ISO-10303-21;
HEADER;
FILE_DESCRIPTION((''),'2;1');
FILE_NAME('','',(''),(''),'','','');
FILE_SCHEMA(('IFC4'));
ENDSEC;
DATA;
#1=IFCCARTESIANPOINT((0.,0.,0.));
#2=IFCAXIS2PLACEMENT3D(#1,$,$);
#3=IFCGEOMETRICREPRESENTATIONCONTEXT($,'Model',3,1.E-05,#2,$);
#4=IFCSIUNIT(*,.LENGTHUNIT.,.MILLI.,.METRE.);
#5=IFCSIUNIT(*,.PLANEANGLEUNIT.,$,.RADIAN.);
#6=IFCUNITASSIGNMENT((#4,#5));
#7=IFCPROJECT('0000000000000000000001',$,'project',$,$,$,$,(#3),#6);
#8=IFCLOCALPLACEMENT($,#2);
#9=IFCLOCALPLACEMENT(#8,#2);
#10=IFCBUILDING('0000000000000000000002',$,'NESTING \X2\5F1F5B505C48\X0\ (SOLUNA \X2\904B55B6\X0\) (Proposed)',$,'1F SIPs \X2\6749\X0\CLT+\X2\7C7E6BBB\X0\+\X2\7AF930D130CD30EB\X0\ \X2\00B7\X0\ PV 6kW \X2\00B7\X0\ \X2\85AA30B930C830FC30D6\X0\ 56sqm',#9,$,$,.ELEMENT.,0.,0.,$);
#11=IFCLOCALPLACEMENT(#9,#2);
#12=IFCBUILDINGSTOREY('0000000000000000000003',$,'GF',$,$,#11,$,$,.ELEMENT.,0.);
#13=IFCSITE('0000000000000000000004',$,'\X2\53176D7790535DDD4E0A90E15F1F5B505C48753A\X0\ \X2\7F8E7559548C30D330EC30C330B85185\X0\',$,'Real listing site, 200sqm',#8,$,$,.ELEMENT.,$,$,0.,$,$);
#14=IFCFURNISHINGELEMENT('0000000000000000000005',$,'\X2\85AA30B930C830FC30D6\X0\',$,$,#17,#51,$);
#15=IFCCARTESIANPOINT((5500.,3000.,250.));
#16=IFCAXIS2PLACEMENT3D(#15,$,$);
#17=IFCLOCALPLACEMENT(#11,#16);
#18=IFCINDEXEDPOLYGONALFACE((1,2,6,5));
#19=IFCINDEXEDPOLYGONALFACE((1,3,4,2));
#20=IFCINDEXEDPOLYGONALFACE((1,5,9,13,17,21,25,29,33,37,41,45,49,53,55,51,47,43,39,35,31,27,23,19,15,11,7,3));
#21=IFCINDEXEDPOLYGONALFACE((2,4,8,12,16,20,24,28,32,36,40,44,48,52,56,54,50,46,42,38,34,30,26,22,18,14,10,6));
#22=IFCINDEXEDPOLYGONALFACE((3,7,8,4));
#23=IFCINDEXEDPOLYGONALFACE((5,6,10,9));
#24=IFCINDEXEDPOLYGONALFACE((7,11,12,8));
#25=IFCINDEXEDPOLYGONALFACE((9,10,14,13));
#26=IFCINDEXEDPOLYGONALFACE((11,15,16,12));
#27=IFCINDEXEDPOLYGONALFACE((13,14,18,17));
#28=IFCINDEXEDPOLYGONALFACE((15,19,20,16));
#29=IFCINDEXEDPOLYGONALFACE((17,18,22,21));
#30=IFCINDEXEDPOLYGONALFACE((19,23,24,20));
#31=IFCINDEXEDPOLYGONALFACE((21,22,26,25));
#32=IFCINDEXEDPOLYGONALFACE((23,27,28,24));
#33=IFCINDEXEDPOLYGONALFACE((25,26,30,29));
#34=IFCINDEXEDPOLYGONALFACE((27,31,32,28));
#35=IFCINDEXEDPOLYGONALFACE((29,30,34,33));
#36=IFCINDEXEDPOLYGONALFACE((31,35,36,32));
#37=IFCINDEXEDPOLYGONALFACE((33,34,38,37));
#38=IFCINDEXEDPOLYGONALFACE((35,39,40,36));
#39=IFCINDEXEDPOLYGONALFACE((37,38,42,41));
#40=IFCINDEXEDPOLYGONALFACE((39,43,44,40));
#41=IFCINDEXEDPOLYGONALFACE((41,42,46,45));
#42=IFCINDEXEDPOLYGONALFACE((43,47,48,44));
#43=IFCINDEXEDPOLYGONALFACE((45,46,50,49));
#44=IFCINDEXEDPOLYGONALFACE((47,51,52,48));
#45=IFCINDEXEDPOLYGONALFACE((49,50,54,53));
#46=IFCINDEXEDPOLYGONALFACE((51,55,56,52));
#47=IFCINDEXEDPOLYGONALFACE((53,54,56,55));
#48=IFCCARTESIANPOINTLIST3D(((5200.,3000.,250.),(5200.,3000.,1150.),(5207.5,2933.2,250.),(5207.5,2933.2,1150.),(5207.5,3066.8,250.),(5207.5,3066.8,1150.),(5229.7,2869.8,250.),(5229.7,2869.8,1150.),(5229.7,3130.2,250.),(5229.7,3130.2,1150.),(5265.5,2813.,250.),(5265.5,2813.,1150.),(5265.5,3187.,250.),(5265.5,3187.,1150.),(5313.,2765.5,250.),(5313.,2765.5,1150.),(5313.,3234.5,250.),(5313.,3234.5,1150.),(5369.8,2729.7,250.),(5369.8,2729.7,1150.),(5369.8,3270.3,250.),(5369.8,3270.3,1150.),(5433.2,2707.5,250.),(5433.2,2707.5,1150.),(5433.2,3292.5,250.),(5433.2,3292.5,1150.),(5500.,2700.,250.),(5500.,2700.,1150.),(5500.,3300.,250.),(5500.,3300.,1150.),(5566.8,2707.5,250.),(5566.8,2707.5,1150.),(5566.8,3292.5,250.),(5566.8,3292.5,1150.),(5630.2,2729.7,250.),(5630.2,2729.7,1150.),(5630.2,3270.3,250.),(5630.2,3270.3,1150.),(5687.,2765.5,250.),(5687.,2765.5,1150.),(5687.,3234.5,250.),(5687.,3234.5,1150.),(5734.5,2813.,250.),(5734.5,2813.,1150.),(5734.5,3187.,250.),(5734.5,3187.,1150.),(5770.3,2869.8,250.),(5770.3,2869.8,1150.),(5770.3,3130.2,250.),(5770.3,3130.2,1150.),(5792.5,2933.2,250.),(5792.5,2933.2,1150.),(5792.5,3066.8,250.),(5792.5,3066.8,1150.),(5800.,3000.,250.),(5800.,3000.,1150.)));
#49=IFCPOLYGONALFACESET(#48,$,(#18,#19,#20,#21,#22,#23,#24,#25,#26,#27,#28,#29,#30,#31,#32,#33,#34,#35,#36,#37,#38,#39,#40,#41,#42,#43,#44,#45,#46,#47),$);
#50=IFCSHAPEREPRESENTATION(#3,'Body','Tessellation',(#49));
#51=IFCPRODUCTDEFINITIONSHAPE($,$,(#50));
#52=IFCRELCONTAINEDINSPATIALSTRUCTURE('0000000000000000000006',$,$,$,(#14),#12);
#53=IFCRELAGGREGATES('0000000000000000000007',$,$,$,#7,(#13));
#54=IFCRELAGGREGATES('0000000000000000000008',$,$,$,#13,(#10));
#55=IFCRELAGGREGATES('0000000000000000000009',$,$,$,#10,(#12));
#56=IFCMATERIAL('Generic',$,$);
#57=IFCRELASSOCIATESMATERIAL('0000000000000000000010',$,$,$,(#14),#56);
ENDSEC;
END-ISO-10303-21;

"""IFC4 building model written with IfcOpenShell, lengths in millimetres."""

from ifc_helpers import new_model, si_unit, frame, origin, origin_2d, place, context, project, spatial, circle, extrude, material, element, save


model = new_model("IFC4")

# Units and contexts
model_context = context("Model", 3, precision=1e-05, world=origin())
ifc_project = project(units=[si_unit("LENGTHUNIT", "METRE", prefix="MILLI"), si_unit("PLANEANGLEUNIT", "RADIAN")], contexts=[model_context])

# Site, building, storey
site_placement = place(None, origin())
site = spatial("IfcSite", under=ifc_project, at=site_placement, Name="北海道川上郡弟子屈町 美留和ビレッジ内", ObjectType="Real listing site, 200sqm", CompositionType="ELEMENT", RefElevation=0.0)
building_placement = place(site_placement, origin())
building = spatial("IfcBuilding", under=site, at=building_placement, Name="NESTING 弟子屈 (SOLUNA 運営) (Proposed)", ObjectType="1F SIPs 杉CLT+籾殻+竹パネル · PV 6kW · 薪ストーブ 56sqm", CompositionType="ELEMENT", ElevationOfRefHeight=0.0, ElevationOfTerrain=0.0)
storey_placement = place(building_placement, origin())
storey = spatial("IfcBuildingStorey", under=building, at=storey_placement, Name="GF", CompositionType="ELEMENT", Elevation=0.0)

# Shared definitions
ifc_material_1 = material(Name="Generic")

# Furnishing element
furnishing_1_placement = place(storey_placement, frame((5500.0, 3000.0, 250.0)))
element("IfcFurnishingElement", 1, at=furnishing_1_placement, inside=storey, material=ifc_material_1, Name="薪ストーブ", context=model_context, shape_type="SweptSolid", body=[
    extrude(circle(Radius=300.0, at=origin_2d()), frame((5500.0, 3000.0, 250.0)), (0.0, 0.0, 1.0), 900.0),
])

save(model, "model.ifc")
